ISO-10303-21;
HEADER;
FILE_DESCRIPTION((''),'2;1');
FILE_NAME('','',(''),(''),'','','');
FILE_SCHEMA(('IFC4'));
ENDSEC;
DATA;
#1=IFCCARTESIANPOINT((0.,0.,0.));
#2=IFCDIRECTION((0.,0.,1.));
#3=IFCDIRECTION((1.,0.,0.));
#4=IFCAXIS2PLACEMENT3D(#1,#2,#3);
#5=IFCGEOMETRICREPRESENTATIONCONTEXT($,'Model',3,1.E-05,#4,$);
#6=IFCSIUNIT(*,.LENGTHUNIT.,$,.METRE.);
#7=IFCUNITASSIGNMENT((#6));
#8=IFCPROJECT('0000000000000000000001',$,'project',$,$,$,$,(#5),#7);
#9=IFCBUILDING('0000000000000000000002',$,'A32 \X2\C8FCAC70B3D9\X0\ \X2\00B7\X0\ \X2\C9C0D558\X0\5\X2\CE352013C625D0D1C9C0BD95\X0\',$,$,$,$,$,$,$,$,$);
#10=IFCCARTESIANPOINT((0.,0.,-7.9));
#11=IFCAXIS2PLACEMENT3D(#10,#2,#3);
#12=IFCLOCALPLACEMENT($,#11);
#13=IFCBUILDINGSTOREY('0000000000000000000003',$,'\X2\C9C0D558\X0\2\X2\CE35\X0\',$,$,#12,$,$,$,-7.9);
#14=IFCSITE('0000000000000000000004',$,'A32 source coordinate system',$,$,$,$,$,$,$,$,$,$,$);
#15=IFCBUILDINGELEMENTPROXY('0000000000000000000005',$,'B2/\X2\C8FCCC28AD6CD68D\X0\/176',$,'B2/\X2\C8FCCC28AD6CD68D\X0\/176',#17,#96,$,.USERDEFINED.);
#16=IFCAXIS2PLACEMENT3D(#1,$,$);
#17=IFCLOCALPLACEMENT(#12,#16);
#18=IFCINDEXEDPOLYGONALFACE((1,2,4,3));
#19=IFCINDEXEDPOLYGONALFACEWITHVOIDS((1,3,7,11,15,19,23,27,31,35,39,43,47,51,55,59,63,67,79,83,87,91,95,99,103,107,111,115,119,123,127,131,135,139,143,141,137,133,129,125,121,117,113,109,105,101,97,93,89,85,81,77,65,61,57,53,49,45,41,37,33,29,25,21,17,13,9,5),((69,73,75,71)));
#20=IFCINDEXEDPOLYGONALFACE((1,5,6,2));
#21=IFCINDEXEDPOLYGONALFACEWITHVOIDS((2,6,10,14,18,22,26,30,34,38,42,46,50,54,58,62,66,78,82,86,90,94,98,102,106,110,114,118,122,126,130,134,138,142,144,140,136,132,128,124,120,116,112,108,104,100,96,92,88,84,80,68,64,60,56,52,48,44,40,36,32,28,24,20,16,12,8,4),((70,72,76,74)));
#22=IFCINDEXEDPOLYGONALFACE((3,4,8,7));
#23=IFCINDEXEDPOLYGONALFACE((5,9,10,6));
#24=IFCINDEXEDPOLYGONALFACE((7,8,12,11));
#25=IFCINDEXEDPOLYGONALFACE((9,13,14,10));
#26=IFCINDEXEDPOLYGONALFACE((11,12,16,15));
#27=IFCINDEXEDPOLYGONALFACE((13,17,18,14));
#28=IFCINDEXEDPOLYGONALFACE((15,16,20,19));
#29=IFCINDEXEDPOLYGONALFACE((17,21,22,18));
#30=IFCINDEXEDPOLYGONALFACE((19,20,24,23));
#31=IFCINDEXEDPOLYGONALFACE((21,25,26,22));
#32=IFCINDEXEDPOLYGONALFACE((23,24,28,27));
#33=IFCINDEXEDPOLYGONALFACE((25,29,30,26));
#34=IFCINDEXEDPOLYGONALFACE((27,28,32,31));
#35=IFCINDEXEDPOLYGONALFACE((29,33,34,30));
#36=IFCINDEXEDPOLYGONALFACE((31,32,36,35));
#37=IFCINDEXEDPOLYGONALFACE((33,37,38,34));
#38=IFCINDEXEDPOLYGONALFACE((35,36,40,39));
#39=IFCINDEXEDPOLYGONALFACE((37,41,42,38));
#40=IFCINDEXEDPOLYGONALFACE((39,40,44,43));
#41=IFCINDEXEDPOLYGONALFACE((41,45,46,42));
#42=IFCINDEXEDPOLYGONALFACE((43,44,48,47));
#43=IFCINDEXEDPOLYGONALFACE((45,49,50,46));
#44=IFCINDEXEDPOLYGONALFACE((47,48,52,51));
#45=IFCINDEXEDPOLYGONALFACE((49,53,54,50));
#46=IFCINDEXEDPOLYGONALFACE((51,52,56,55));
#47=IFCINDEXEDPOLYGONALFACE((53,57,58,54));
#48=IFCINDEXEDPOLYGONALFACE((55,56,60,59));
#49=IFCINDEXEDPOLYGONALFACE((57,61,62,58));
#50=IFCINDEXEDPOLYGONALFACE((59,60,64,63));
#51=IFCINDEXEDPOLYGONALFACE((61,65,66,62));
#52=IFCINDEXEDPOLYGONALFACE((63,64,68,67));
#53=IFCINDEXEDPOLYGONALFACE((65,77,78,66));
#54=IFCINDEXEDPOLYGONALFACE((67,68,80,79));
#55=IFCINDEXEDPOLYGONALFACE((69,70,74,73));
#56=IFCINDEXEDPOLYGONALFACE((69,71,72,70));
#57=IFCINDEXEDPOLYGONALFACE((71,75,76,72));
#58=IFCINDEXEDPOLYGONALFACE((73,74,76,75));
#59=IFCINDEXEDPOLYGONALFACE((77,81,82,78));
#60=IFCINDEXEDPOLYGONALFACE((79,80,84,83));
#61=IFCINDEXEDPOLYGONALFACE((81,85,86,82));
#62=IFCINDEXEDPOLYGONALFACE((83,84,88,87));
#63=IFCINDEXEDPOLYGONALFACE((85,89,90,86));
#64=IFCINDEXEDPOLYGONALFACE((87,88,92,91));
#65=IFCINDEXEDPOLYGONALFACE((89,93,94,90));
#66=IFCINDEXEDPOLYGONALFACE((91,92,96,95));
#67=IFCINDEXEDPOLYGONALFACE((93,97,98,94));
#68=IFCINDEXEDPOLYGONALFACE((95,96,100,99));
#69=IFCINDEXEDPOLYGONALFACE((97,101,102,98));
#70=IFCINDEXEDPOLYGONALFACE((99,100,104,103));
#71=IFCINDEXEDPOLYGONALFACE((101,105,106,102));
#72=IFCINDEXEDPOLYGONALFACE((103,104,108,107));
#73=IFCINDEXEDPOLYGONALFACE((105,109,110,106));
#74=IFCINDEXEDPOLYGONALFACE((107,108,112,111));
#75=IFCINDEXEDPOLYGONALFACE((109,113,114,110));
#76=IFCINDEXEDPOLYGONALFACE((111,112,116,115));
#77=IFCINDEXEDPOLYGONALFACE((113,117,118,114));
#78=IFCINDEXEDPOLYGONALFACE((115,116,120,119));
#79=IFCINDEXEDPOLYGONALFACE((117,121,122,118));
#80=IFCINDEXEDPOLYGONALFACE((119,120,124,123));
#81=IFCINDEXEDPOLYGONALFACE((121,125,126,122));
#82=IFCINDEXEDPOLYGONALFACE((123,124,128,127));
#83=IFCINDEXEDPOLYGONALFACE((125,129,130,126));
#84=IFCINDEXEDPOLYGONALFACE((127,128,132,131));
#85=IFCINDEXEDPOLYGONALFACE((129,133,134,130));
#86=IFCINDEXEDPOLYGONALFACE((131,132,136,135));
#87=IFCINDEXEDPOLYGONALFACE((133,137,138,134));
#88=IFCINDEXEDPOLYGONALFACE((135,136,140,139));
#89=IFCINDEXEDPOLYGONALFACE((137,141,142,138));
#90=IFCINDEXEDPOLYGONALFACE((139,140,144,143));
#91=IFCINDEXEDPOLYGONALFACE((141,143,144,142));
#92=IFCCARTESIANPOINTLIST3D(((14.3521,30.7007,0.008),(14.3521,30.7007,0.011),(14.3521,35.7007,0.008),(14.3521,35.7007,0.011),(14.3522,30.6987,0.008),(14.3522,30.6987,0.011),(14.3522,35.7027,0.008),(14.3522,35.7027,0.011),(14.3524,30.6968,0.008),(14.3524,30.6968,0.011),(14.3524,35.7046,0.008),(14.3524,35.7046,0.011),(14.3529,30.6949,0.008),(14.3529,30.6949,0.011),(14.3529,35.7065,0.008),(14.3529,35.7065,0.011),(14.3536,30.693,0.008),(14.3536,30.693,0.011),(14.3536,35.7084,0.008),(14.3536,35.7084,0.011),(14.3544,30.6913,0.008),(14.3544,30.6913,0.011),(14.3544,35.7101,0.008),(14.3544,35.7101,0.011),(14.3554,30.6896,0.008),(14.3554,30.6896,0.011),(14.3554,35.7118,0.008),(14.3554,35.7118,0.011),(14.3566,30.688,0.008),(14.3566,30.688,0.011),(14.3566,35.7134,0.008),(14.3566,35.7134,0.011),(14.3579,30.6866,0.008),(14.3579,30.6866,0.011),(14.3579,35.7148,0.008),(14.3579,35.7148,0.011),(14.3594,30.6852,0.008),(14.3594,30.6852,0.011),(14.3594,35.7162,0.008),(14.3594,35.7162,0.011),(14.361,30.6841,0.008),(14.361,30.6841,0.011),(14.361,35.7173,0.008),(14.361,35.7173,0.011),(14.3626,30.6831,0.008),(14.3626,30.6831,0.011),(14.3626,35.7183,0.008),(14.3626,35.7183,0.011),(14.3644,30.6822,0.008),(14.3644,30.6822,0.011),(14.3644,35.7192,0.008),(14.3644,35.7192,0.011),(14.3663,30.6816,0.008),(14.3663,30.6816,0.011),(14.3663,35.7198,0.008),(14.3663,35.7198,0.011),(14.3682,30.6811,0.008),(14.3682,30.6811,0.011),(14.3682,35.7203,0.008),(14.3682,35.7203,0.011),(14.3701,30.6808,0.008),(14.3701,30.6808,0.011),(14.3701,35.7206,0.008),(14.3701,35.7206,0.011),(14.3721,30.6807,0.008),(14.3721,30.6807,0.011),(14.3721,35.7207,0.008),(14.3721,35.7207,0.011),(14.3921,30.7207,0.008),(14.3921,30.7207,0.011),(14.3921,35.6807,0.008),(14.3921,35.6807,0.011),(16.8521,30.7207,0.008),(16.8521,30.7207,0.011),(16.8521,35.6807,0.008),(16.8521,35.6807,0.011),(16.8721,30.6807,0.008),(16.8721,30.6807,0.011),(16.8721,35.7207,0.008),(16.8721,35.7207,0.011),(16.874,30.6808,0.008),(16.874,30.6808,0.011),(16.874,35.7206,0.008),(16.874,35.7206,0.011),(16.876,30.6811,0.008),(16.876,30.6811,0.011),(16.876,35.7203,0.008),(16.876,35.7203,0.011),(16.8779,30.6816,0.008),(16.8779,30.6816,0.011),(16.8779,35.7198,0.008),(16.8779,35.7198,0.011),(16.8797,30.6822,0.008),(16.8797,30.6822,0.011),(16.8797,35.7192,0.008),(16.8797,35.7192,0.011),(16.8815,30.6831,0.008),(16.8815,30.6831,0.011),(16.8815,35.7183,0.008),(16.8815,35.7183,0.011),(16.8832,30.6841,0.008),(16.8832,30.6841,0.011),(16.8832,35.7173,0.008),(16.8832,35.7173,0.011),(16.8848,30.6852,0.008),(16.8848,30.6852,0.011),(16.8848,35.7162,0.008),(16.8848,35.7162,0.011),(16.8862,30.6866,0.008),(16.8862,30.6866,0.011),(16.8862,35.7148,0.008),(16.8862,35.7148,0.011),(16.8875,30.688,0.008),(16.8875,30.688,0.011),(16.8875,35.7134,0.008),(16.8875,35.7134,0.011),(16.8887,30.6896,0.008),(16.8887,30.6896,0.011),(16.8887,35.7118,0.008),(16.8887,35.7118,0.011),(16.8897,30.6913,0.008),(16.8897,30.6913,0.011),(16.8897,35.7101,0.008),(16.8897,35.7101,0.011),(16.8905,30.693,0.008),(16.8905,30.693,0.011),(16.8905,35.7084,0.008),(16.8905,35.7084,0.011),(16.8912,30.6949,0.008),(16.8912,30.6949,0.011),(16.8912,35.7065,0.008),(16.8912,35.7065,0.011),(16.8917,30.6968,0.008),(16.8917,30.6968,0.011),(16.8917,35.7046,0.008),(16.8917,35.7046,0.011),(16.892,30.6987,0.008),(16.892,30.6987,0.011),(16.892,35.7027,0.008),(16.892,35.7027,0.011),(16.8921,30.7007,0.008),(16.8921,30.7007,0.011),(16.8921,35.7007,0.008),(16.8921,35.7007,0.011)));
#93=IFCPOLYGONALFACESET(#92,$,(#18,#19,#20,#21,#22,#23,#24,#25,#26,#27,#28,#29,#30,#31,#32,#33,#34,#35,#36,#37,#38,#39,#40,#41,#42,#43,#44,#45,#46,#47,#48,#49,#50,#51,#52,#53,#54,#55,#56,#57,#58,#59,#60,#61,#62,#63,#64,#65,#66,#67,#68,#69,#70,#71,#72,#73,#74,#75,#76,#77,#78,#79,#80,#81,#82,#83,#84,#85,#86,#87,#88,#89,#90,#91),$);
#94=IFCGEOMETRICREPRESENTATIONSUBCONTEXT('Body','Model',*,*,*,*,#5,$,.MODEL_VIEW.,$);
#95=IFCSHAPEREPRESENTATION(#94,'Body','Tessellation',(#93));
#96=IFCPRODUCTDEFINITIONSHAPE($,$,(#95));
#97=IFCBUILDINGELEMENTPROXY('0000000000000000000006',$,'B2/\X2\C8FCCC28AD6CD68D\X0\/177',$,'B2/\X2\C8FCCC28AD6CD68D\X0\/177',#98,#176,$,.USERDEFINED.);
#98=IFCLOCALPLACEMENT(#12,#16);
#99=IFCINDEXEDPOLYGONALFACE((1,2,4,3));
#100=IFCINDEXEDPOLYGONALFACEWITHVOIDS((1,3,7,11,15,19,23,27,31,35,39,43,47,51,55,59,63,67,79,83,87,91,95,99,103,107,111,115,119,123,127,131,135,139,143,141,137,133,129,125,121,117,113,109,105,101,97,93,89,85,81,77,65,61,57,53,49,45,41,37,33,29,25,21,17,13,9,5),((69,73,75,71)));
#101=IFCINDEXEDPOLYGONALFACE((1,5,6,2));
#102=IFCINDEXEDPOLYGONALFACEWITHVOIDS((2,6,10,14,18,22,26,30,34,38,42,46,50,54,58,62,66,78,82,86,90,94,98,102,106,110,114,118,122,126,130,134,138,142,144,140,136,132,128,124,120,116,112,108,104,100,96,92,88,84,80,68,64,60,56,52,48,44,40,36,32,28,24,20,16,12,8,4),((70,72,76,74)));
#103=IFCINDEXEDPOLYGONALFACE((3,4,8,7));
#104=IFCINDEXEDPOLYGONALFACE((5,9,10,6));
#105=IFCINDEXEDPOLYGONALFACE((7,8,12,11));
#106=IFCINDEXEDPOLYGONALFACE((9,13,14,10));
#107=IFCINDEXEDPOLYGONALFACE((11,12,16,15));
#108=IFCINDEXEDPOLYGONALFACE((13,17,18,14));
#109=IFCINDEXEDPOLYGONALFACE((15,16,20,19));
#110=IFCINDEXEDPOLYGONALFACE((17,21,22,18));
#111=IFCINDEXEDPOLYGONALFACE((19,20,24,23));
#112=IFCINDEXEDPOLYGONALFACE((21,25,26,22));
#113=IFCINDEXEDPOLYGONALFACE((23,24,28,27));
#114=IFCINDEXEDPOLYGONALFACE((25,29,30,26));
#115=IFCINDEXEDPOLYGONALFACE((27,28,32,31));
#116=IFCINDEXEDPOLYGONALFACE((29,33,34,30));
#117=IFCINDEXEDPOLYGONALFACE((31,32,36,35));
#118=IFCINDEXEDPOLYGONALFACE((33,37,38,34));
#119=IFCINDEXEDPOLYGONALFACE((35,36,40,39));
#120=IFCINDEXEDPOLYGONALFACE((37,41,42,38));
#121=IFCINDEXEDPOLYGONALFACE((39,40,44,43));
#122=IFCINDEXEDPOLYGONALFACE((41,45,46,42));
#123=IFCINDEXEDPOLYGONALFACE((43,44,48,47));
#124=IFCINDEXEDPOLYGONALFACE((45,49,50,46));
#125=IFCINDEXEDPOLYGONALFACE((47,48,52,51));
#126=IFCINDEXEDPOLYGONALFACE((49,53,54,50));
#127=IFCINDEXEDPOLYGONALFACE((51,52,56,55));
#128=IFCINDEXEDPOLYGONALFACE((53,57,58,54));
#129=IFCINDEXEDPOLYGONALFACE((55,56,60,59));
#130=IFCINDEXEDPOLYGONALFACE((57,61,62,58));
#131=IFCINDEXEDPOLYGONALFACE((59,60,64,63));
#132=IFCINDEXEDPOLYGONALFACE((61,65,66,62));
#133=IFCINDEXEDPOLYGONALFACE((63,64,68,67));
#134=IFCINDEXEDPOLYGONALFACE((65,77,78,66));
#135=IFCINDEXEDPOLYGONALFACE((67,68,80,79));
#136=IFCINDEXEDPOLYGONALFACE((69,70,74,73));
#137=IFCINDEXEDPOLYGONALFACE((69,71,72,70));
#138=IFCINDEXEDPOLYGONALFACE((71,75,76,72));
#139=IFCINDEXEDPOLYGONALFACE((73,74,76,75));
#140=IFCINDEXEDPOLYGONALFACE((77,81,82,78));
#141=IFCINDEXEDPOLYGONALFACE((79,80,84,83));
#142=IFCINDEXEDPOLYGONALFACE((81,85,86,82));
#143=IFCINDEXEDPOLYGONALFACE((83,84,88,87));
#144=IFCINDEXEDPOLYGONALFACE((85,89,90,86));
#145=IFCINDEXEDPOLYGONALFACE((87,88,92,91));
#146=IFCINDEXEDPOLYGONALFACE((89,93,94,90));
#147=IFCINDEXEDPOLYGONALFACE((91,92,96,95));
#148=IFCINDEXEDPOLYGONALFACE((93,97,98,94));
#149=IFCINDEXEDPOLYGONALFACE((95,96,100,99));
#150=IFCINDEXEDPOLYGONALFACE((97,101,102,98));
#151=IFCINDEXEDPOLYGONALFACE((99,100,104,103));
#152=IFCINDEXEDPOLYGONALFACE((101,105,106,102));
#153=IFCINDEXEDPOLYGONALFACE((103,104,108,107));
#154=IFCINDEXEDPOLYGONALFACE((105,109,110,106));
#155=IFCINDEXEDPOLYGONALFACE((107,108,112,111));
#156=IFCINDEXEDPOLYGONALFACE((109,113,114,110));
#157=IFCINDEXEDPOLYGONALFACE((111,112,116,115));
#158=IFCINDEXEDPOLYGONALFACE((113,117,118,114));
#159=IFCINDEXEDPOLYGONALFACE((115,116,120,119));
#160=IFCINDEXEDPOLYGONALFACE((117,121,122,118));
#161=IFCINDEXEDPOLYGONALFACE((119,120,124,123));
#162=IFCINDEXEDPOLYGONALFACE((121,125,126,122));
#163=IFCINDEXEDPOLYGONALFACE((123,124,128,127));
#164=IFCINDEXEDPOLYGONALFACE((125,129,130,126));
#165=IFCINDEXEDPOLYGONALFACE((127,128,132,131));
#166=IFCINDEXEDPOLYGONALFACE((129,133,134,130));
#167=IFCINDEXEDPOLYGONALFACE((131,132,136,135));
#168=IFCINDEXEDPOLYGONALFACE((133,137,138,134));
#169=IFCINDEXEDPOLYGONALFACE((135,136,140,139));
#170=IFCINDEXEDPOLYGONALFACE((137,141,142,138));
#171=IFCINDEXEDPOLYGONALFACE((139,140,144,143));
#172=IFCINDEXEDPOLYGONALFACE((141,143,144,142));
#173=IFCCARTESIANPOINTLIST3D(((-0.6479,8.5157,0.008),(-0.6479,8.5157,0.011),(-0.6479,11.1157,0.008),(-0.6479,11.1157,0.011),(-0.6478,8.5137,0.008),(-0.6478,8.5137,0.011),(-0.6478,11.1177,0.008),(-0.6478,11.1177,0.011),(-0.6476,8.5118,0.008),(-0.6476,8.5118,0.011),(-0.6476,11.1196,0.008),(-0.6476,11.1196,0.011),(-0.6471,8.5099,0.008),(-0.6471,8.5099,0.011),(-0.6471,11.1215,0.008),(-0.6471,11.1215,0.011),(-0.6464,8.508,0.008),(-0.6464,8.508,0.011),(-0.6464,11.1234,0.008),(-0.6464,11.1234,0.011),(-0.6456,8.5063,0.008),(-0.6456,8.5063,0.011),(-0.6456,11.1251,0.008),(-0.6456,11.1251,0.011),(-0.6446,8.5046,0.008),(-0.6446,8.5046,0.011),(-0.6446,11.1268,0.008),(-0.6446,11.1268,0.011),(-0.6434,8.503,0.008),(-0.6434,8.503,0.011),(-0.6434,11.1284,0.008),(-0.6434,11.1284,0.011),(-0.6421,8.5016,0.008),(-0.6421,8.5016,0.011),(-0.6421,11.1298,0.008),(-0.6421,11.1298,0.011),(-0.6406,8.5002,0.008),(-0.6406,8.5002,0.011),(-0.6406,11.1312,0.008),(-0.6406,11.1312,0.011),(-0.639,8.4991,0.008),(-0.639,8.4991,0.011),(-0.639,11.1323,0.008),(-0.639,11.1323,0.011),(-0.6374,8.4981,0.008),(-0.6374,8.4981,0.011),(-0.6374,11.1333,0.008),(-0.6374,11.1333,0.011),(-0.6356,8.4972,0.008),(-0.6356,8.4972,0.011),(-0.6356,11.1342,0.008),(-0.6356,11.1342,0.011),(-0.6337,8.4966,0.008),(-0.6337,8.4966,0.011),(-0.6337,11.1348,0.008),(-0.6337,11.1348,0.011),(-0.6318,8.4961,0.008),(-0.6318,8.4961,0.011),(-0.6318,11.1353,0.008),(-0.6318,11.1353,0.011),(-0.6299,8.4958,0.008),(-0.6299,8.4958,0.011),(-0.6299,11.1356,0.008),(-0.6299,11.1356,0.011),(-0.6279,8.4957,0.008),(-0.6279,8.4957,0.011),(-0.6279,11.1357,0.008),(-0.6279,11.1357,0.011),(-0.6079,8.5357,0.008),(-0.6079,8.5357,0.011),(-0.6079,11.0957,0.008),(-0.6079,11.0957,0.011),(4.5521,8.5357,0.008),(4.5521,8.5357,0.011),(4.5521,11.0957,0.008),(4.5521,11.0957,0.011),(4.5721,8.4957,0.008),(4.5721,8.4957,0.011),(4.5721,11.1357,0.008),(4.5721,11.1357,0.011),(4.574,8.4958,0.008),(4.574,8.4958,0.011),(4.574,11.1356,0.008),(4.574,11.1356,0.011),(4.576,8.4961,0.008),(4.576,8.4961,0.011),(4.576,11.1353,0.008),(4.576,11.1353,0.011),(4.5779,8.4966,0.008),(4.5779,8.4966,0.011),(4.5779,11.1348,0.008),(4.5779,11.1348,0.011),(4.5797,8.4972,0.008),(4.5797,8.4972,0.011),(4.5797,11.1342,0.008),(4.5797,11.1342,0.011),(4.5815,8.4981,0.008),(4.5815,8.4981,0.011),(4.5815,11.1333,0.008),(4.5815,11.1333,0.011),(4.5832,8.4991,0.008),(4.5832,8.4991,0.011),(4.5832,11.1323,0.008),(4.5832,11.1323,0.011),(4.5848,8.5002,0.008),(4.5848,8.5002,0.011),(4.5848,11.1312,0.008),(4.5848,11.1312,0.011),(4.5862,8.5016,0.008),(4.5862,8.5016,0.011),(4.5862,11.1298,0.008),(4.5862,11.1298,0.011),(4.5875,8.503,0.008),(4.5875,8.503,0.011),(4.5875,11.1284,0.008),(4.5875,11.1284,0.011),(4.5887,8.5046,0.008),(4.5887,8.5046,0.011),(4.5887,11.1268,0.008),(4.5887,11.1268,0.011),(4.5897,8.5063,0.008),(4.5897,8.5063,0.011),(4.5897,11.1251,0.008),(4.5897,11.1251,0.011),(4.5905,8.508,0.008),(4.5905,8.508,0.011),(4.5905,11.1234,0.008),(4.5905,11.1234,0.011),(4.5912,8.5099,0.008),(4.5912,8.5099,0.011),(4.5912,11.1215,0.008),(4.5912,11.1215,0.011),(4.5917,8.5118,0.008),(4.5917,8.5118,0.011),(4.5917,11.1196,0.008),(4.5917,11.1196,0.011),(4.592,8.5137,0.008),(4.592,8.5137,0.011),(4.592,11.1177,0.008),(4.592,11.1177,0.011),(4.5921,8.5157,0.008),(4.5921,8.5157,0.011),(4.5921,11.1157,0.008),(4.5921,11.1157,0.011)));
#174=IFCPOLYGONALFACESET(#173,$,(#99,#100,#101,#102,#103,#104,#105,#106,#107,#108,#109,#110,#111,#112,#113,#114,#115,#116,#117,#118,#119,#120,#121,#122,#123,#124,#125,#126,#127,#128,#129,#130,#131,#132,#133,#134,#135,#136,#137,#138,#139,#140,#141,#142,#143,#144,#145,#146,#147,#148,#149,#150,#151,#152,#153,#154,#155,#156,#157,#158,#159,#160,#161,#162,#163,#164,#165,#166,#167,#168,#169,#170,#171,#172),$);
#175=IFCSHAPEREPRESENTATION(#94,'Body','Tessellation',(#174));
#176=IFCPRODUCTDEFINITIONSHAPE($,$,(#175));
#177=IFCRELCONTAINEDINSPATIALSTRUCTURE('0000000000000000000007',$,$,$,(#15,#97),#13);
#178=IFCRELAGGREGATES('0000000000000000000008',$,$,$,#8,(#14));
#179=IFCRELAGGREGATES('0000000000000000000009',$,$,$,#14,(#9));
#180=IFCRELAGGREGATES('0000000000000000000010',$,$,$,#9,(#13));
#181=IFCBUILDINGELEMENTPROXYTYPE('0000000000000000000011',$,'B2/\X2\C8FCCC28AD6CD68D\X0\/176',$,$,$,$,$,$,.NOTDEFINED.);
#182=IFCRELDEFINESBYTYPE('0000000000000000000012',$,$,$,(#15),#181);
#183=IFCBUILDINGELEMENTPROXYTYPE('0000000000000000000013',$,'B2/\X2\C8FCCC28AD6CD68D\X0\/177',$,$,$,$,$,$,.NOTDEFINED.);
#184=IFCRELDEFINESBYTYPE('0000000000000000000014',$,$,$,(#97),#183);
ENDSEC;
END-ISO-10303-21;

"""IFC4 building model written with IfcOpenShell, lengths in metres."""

from ifc_helpers import new_model, si_unit, frame, origin, origin_with_axes, place, context, subcontext, project, spatial, polyline, outline, extrude, source, transform, mapped, type_object, type_shapes, element, save


model = new_model("IFC4")

# Units and contexts
model_context = context("Model", 3, precision=1e-05, world=origin_with_axes())
body_context = subcontext(model_context, "Body", "Model", "MODEL_VIEW")
ifc_project = project(units=[si_unit("LENGTHUNIT", "METRE")], contexts=[model_context])

# Site, building, storey
site = spatial("IfcSite", under=ifc_project, Name="A32 source coordinate system")
building = spatial("IfcBuilding", under=site, Name="A32 주거동 · 지하5층–옥탑지붕")
storey_placement = place(None, frame((0.0, 0.0, -7.9), z_axis=(0.0, 0.0, 1.0), x_axis=(1.0, 0.0, 0.0)))
storey = spatial("IfcBuildingStorey", under=building, at=storey_placement, Name="지하2층", Elevation=-7.9)

# Building element proxies
building_element_proxy_type_1 = type_object("IfcBuildingElementProxyType", Name="B2/주차구획/176", PredefinedType="NOTDEFINED")
shared_shape_1 = source(origin(), body_context, "Body", "SweptSolid", [
    extrude(outline(polyline([(14.3521, 35.7007), (14.3522, 35.7027), (14.3524, 35.7046), (14.3529, 35.7065), (14.3536, 35.7084), (14.3544, 35.7101), (14.3554, 35.7118), (14.3566, 35.7134), (14.3579, 35.7148), (14.3594, 35.7162), (14.361, 35.7173), (14.3626, 35.7183), (14.3644, 35.7192), (14.3663, 35.7198), (14.3682, 35.7203), (14.3701, 35.7206), (14.3721, 35.7207), (16.8721, 35.7207), (16.874, 35.7206), (16.876, 35.7203), (16.8779, 35.7198), (16.8797, 35.7192), (16.8815, 35.7183), (16.8832, 35.7173), (16.8848, 35.7162), (16.8862, 35.7148), (16.8875, 35.7134), (16.8887, 35.7118), (16.8897, 35.7101), (16.8905, 35.7084), (16.8912, 35.7065), (16.8917, 35.7046), (16.892, 35.7027), (16.8921, 35.7007), (16.8921, 30.7007), (16.892, 30.6987), (16.8917, 30.6968), (16.8912, 30.6949), (16.8905, 30.693), (16.8897, 30.6913), (16.8887, 30.6896), (16.8875, 30.688), (16.8862, 30.6866), (16.8848, 30.6852), (16.8832, 30.6841), (16.8815, 30.6831), (16.8797, 30.6822), (16.8779, 30.6816), (16.876, 30.6811), (16.874, 30.6808), (16.8721, 30.6807), (14.3721, 30.6807), (14.3701, 30.6808), (14.3682, 30.6811), (14.3663, 30.6816), (14.3644, 30.6822), (14.3626, 30.6831), (14.361, 30.6841), (14.3594, 30.6852), (14.3579, 30.6866), (14.3566, 30.688), (14.3554, 30.6896), (14.3544, 30.6913), (14.3536, 30.693), (14.3529, 30.6949), (14.3524, 30.6968), (14.3522, 30.6987), (14.3521, 30.7007), (14.3521, 35.7007)]), holes=[polyline([(14.3921, 35.6807), (14.3921, 30.7207), (16.8521, 30.7207), (16.8521, 35.6807), (14.3921, 35.6807)])]), frame((0.0, 0.0, 0.008)), (0.0, 0.0, 1.0), 0.003),
])
type_shapes(building_element_proxy_type_1, [shared_shape_1])
proxy_1_placement = place(storey_placement, origin_with_axes())
element("IfcBuildingElementProxy", 1, at=proxy_1_placement, inside=storey, type_object=building_element_proxy_type_1, Name="B2/주차구획/176", ObjectType="B2/주차구획/176", PredefinedType="USERDEFINED", context=body_context, shape_type="MappedRepresentation", body=[
    mapped(shared_shape_1, transform((0.0, 0.0, 0.0), scale=1.0)),
])
building_element_proxy_type_2 = type_object("IfcBuildingElementProxyType", Name="B2/주차구획/177", PredefinedType="NOTDEFINED")
shared_shape_2 = source(origin(), body_context, "Body", "SweptSolid", [
    extrude(outline(polyline([(4.5921, 8.5157), (4.592, 8.5137), (4.5917, 8.5118), (4.5912, 8.5099), (4.5905, 8.508), (4.5897, 8.5063), (4.5887, 8.5046), (4.5875, 8.503), (4.5862, 8.5016), (4.5848, 8.5002), (4.5832, 8.4991), (4.5815, 8.4981), (4.5797, 8.4972), (4.5779, 8.4966), (4.576, 8.4961), (4.574, 8.4958), (4.5721, 8.4957), (-0.6279, 8.4957), (-0.6299, 8.4958), (-0.6318, 8.4961), (-0.6337, 8.4966), (-0.6356, 8.4972), (-0.6374, 8.4981), (-0.639, 8.4991), (-0.6406, 8.5002), (-0.6421, 8.5016), (-0.6434, 8.503), (-0.6446, 8.5046), (-0.6456, 8.5063), (-0.6464, 8.508), (-0.6471, 8.5099), (-0.6476, 8.5118), (-0.6478, 8.5137), (-0.6479, 8.5157), (-0.6479, 11.1157), (-0.6478, 11.1177), (-0.6476, 11.1196), (-0.6471, 11.1215), (-0.6464, 11.1234), (-0.6456, 11.1251), (-0.6446, 11.1268), (-0.6434, 11.1284), (-0.6421, 11.1298), (-0.6406, 11.1312), (-0.639, 11.1323), (-0.6374, 11.1333), (-0.6356, 11.1342), (-0.6337, 11.1348), (-0.6318, 11.1353), (-0.6299, 11.1356), (-0.6279, 11.1357), (4.5721, 11.1357), (4.574, 11.1356), (4.576, 11.1353), (4.5779, 11.1348), (4.5797, 11.1342), (4.5815, 11.1333), (4.5832, 11.1323), (4.5848, 11.1312), (4.5862, 11.1298), (4.5875, 11.1284), (4.5887, 11.1268), (4.5897, 11.1251), (4.5905, 11.1234), (4.5912, 11.1215), (4.5917, 11.1196), (4.592, 11.1177), (4.5921, 11.1157), (4.5921, 8.5157)]), holes=[polyline([(4.5521, 8.5357), (4.5521, 11.0957), (-0.6079, 11.0957), (-0.6079, 8.5357), (4.5521, 8.5357)])]), frame((0.0, 0.0, 0.008)), (0.0, 0.0, 1.0), 0.003),
])
type_shapes(building_element_proxy_type_2, [shared_shape_2])
proxy_2_placement = place(storey_placement, origin_with_axes())
element("IfcBuildingElementProxy", 2, at=proxy_2_placement, inside=storey, type_object=building_element_proxy_type_2, Name="B2/주차구획/177", ObjectType="B2/주차구획/177", PredefinedType="USERDEFINED", context=body_context, shape_type="MappedRepresentation", body=[
    mapped(shared_shape_2, transform((0.0, 0.0, 0.0), scale=1.0)),
])

save(model, "model.ifc")
